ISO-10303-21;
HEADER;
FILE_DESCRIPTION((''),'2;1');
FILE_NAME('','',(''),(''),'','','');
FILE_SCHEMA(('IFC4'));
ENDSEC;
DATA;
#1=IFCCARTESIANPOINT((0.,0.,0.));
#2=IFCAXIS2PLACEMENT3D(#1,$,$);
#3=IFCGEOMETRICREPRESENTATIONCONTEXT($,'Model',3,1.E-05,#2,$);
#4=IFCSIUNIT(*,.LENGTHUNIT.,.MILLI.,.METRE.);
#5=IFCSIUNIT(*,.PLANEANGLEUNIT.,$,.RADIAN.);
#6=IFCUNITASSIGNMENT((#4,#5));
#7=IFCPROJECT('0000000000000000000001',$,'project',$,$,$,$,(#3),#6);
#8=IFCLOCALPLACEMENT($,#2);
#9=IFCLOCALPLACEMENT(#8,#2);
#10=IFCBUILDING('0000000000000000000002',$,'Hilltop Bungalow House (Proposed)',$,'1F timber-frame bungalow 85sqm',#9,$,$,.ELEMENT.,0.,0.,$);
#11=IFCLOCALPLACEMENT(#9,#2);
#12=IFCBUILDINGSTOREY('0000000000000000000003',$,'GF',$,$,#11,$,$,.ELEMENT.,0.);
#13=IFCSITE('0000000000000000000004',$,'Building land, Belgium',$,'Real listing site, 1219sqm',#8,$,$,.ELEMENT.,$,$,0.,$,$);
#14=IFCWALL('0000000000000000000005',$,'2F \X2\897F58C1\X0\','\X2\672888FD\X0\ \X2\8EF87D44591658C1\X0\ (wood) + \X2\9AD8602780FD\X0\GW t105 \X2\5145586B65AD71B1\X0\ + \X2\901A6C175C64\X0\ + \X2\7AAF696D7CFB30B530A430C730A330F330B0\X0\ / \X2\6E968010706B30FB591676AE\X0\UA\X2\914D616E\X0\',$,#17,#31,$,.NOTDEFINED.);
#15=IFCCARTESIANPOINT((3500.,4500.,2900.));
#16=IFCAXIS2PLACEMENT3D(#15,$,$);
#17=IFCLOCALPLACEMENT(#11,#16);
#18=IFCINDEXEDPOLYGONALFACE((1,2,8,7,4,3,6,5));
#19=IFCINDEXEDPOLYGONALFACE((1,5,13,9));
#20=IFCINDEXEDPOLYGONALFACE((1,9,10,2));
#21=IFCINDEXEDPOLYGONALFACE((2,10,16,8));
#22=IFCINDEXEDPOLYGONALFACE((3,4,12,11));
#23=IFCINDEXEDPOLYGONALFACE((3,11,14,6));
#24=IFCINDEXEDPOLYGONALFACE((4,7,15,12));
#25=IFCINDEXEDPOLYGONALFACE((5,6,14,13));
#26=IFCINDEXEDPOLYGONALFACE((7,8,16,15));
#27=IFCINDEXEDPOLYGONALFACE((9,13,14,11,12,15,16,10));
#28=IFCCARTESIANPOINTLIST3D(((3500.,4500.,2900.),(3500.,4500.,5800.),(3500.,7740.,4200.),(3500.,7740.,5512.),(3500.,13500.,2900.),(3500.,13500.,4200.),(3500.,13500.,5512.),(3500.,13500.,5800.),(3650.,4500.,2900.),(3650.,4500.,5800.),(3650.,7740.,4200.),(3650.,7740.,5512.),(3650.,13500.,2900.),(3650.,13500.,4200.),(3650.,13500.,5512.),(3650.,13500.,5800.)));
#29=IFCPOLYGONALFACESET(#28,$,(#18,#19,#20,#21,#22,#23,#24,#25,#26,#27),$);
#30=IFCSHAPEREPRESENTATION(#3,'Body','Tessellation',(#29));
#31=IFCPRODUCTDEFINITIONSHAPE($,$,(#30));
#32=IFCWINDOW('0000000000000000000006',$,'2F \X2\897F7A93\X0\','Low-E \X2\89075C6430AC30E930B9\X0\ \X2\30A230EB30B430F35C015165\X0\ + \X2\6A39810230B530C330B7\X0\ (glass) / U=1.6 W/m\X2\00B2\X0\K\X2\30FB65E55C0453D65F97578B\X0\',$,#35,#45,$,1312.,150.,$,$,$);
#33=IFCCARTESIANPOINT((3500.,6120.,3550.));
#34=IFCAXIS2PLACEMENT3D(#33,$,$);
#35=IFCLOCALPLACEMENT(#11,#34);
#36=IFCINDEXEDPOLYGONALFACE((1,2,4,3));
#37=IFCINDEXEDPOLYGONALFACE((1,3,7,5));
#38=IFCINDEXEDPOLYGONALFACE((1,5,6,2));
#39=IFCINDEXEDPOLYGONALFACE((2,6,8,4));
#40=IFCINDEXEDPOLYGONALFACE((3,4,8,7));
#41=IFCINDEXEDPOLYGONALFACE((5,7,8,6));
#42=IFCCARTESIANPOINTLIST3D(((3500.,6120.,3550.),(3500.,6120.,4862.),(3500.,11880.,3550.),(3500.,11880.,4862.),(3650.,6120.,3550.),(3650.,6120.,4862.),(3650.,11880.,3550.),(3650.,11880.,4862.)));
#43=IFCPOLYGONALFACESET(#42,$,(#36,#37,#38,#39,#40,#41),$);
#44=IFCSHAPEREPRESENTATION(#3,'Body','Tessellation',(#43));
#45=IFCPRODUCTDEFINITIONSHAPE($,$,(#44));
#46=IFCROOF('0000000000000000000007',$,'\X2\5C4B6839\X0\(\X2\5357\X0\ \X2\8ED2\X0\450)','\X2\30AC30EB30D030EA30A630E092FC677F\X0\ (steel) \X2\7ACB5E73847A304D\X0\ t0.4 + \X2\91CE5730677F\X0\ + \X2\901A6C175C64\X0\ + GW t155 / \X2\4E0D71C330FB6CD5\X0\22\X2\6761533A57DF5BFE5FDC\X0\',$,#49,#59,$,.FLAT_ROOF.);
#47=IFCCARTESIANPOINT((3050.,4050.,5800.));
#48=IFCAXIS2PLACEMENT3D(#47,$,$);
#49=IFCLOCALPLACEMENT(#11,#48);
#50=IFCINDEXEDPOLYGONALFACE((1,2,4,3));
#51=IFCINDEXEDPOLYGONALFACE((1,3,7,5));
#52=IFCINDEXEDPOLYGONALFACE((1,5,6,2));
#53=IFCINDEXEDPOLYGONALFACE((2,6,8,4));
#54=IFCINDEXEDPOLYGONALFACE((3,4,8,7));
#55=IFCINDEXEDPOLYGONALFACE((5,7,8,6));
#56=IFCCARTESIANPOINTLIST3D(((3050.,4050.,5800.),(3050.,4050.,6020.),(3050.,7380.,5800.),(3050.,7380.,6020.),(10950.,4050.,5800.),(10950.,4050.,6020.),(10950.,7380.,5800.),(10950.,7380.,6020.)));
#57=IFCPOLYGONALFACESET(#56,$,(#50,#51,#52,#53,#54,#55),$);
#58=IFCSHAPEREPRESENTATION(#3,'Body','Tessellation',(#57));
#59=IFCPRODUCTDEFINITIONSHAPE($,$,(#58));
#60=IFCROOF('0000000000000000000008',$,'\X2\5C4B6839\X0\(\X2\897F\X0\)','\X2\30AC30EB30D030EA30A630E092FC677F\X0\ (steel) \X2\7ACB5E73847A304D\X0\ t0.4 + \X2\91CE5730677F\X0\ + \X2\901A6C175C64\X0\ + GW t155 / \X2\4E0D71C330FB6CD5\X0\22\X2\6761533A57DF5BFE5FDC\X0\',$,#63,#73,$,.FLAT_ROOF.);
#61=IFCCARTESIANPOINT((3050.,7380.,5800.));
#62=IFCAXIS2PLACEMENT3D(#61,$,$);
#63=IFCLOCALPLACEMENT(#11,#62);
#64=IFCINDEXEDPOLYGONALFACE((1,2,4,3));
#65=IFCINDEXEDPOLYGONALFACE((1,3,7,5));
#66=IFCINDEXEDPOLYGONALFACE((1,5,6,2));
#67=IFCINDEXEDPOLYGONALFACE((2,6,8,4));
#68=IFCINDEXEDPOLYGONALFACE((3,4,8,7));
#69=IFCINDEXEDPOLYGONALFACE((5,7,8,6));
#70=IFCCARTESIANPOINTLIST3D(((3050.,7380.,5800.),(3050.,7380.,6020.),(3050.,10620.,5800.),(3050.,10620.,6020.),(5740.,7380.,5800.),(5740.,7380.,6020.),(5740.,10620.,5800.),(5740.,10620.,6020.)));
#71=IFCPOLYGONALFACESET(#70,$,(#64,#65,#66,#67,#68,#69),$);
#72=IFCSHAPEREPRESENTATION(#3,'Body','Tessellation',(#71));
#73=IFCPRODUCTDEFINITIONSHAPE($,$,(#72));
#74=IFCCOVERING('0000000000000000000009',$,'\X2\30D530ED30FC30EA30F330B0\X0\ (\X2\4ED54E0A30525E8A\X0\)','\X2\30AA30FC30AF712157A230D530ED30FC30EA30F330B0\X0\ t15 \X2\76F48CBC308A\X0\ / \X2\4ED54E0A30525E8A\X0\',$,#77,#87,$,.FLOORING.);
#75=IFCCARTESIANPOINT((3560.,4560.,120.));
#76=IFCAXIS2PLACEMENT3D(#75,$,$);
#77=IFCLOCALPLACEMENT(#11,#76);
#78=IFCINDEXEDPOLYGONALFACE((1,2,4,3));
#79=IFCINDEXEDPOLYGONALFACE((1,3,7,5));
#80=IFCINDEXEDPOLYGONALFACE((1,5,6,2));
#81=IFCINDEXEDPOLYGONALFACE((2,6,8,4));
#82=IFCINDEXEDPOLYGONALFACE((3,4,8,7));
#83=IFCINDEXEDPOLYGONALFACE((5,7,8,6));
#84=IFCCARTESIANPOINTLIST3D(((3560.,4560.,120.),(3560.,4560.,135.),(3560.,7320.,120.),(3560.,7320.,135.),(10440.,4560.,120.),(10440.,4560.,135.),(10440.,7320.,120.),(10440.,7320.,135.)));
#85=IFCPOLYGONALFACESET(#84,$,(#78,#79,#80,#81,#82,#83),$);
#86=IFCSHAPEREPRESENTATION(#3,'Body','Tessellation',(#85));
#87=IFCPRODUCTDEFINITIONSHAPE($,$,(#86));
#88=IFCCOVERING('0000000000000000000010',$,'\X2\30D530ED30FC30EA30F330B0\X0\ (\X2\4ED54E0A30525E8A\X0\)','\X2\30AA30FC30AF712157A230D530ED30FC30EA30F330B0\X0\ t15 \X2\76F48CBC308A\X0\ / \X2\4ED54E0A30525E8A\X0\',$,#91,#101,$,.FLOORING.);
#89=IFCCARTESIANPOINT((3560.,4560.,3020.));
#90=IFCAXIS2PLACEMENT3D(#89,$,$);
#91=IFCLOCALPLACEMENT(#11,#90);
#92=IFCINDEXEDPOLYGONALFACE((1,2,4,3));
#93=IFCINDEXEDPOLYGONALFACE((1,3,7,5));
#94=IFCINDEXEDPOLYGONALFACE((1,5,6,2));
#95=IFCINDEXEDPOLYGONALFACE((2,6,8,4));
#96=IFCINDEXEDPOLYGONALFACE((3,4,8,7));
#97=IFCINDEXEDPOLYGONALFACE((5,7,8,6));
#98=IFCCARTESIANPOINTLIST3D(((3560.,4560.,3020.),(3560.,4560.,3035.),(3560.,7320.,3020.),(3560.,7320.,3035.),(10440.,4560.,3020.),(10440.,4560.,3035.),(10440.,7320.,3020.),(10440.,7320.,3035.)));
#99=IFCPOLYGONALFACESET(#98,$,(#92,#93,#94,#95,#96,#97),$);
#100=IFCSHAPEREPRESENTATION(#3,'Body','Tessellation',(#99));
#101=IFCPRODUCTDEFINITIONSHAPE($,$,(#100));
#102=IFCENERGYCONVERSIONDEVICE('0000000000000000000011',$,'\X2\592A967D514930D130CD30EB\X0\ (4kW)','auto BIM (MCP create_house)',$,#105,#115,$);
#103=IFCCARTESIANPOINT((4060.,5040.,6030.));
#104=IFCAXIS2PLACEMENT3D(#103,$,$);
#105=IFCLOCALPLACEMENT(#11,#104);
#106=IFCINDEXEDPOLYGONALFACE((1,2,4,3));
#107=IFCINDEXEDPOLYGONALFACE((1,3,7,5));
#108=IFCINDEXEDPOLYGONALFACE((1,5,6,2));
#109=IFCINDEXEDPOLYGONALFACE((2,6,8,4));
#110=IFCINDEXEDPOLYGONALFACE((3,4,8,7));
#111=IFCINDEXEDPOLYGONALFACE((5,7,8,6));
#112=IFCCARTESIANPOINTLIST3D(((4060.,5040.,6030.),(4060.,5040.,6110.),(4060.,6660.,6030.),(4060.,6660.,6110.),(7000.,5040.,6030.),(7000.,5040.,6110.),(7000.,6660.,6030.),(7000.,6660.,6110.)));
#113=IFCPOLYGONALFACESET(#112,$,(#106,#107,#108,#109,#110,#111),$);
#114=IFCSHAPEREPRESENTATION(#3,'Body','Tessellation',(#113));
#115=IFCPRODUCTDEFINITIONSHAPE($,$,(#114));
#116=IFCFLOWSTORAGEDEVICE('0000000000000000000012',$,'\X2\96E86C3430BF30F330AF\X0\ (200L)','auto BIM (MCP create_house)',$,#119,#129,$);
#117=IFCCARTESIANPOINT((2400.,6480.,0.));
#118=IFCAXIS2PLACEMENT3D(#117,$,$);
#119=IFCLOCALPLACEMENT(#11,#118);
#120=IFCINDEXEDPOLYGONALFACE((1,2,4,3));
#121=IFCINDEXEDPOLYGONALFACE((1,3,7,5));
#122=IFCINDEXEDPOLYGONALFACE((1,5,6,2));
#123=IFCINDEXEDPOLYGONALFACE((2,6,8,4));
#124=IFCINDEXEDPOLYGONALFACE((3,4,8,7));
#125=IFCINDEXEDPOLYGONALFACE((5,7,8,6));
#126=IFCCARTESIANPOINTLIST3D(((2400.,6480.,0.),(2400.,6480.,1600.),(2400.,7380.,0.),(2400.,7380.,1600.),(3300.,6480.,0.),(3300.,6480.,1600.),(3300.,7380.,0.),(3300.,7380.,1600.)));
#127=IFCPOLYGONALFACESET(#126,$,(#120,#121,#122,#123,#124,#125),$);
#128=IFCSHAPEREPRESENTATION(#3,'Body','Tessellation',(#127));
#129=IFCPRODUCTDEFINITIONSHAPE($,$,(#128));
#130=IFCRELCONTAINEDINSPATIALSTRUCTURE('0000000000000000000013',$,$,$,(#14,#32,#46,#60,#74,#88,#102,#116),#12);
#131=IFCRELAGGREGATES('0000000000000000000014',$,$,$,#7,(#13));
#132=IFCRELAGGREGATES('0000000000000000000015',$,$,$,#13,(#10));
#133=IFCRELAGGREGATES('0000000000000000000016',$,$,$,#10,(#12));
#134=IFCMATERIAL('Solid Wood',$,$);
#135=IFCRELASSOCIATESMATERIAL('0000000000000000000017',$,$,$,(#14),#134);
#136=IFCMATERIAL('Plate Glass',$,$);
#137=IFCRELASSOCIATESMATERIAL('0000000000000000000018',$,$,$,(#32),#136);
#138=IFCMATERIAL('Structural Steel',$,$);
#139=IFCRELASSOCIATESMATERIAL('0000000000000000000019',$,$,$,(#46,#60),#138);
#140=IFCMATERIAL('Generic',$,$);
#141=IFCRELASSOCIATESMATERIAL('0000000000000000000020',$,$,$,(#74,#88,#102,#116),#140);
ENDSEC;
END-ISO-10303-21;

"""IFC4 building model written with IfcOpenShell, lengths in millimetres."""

from ifc_helpers import new_model, si_unit, frame, frame_2d, origin, place, context, project, spatial, rectangle, extrude, material, element, fill, save


model = new_model("IFC4")

# Units and contexts
model_context = context("Model", 3, precision=1e-05, world=origin())
ifc_project = project(units=[si_unit("LENGTHUNIT", "METRE", prefix="MILLI"), si_unit("PLANEANGLEUNIT", "RADIAN")], contexts=[model_context])

# Site, building, storey
site_placement = place(None, origin())
site = spatial("IfcSite", under=ifc_project, at=site_placement, Name="Building land, Belgium", ObjectType="Real listing site, 1219sqm", CompositionType="ELEMENT", RefElevation=0.0)
building_placement = place(site_placement, origin())
building = spatial("IfcBuilding", under=site, at=building_placement, Name="Hilltop Bungalow House (Proposed)", ObjectType="1F timber-frame bungalow 85sqm", CompositionType="ELEMENT", ElevationOfRefHeight=0.0, ElevationOfTerrain=0.0)
storey_placement = place(building_placement, origin())
storey = spatial("IfcBuildingStorey", under=building, at=storey_placement, Name="GF", CompositionType="ELEMENT", Elevation=0.0)

# Shared definitions
ifc_material_1 = material(Name="Solid Wood")
ifc_material_2 = material(Name="Generic")

# Shared definitions
ifc_material_3 = material(Name="Plate Glass")

# Wall, opening, window
wall_1_placement = place(storey_placement, frame((3500.0, 4500.0, 2900.0)))
wall_1 = element("IfcWall", 1, at=wall_1_placement, inside=storey, material=ifc_material_1, Name="2F 西壁", Description="木製 軸組外壁 (wood) + 高性能GW t105 充填断熱 + 通気層 + 窯業系サイディング / 準耐火・外皮UA配慮", PredefinedType="NOTDEFINED", context=model_context, shape_type="SweptSolid", body=[
    extrude(rectangle(XDim=150.0, YDim=9000.0, at=frame_2d((75.0, 4500.0))), frame((3500.0, 4500.0, 2900.0)), (0.0, 0.0, 1.0), 2900.0),
])
opening_1_placement = place(storey_placement, frame((3500.0, 6120.0, 3550.0)))
opening_1 = element("IfcOpeningElement", 2, at=opening_1_placement, cuts=wall_1, PredefinedType="NOTDEFINED", context=model_context, shape_type="SweptSolid", body=[
    extrude(rectangle(XDim=150.0, YDim=5760.0, at=frame_2d((75.0, 2880.0))), frame((3500.0, 6120.0, 3550.0)), (0.0, 0.0, 1.0), 1312.0),
])
window_1_placement = place(storey_placement, frame((3500.0, 6120.0, 3550.0)))
window_1 = element("IfcWindow", 3, at=window_1_placement, inside=storey, material=ifc_material_3, Name="2F 西窓", Description="Low-E 複層ガラス アルゴン封入 + 樹脂サッシ (glass) / U=1.6 W/m²K・日射取得型", OverallHeight=1312.0, OverallWidth=150.0, context=model_context, shape_type="SweptSolid", body=[
    extrude(rectangle(XDim=150.0, YDim=5760.0, at=frame_2d((75.0, 2880.0))), frame((3500.0, 6120.0, 3550.0)), (0.0, 0.0, 1.0), 1312.0),
])
fill(opening_1, window_1)

# Roofs
ifc_material_4 = material(Name="Structural Steel")
roof_1_placement = place(storey_placement, frame((3050.0, 4050.0, 5800.0)))
element("IfcRoof", 4, at=roof_1_placement, inside=storey, material=ifc_material_4, Name="屋根(南 軒450)", Description="ガルバリウム鋼板 (steel) 立平葺き t0.4 + 野地板 + 通気層 + GW t155 / 不燃・法22条区域対応", PredefinedType="FLAT_ROOF", context=model_context, shape_type="SweptSolid", body=[
    extrude(rectangle(XDim=7900.0, YDim=3330.0, at=frame_2d((3950.0, 1665.0))), frame((3050.0, 4050.0, 5800.0)), (0.0, 0.0, 1.0), 220.0),
])
roof_2_placement = place(storey_placement, frame((3050.0, 7380.0, 5800.0)))
element("IfcRoof", 5, at=roof_2_placement, inside=storey, material=ifc_material_4, Name="屋根(西)", Description="ガルバリウム鋼板 (steel) 立平葺き t0.4 + 野地板 + 通気層 + GW t155 / 不燃・法22条区域対応", PredefinedType="FLAT_ROOF", context=model_context, shape_type="SweptSolid", body=[
    extrude(rectangle(XDim=2690.0, YDim=3240.0, at=frame_2d((1345.0, 1620.0))), frame((3050.0, 7380.0, 5800.0)), (0.0, 0.0, 1.0), 220.0),
])

# Coverings
covering_1_placement = place(storey_placement, frame((3560.0, 4560.0, 120.0)))
element("IfcCovering", 6, at=covering_1_placement, inside=storey, material=ifc_material_2, Name="フローリング (仕上げ床)", Description="オーク無垢フローリング t15 直貼り / 仕上げ床", PredefinedType="FLOORING", context=model_context, shape_type="SweptSolid", body=[
    extrude(rectangle(XDim=6880.0, YDim=2760.0, at=frame_2d((3440.0, 1380.0))), frame((3560.0, 4560.0, 120.0)), (0.0, 0.0, 1.0), 15.0),
])
covering_2_placement = place(storey_placement, frame((3560.0, 4560.0, 3020.0)))
element("IfcCovering", 7, at=covering_2_placement, inside=storey, material=ifc_material_2, Name="フローリング (仕上げ床)", Description="オーク無垢フローリング t15 直貼り / 仕上げ床", PredefinedType="FLOORING", context=model_context, shape_type="SweptSolid", body=[
    extrude(rectangle(XDim=6880.0, YDim=2760.0, at=frame_2d((3440.0, 1380.0))), frame((3560.0, 4560.0, 3020.0)), (0.0, 0.0, 1.0), 15.0),
])

# Energy conversion device
energy_conversion_device_placement = place(storey_placement, frame((4060.0, 5040.0, 6030.0)))
element("IfcEnergyConversionDevice", 8, at=energy_conversion_device_placement, inside=storey, material=ifc_material_2, Name="太陽光パネル (4kW)", Description="auto BIM (MCP create_house)", context=model_context, shape_type="SweptSolid", body=[
    extrude(rectangle(XDim=2940.0, YDim=1620.0, at=frame_2d((1470.0, 810.0))), frame((4060.0, 5040.0, 6030.0)), (0.0, 0.0, 1.0), 80.0),
])

# Flow storage device
flow_storage_device_placement = place(storey_placement, frame((2400.0, 6480.0, 0.0)))
element("IfcFlowStorageDevice", 9, at=flow_storage_device_placement, inside=storey, material=ifc_material_2, Name="雨水タンク (200L)", Description="auto BIM (MCP create_house)", context=model_context, shape_type="SweptSolid", body=[
    extrude(rectangle(XDim=900.0, YDim=900.0, at=frame_2d((450.0, 450.0))), frame((2400.0, 6480.0, 0.0)), (0.0, 0.0, 1.0), 1600.0),
])

save(model, "model.ifc")
